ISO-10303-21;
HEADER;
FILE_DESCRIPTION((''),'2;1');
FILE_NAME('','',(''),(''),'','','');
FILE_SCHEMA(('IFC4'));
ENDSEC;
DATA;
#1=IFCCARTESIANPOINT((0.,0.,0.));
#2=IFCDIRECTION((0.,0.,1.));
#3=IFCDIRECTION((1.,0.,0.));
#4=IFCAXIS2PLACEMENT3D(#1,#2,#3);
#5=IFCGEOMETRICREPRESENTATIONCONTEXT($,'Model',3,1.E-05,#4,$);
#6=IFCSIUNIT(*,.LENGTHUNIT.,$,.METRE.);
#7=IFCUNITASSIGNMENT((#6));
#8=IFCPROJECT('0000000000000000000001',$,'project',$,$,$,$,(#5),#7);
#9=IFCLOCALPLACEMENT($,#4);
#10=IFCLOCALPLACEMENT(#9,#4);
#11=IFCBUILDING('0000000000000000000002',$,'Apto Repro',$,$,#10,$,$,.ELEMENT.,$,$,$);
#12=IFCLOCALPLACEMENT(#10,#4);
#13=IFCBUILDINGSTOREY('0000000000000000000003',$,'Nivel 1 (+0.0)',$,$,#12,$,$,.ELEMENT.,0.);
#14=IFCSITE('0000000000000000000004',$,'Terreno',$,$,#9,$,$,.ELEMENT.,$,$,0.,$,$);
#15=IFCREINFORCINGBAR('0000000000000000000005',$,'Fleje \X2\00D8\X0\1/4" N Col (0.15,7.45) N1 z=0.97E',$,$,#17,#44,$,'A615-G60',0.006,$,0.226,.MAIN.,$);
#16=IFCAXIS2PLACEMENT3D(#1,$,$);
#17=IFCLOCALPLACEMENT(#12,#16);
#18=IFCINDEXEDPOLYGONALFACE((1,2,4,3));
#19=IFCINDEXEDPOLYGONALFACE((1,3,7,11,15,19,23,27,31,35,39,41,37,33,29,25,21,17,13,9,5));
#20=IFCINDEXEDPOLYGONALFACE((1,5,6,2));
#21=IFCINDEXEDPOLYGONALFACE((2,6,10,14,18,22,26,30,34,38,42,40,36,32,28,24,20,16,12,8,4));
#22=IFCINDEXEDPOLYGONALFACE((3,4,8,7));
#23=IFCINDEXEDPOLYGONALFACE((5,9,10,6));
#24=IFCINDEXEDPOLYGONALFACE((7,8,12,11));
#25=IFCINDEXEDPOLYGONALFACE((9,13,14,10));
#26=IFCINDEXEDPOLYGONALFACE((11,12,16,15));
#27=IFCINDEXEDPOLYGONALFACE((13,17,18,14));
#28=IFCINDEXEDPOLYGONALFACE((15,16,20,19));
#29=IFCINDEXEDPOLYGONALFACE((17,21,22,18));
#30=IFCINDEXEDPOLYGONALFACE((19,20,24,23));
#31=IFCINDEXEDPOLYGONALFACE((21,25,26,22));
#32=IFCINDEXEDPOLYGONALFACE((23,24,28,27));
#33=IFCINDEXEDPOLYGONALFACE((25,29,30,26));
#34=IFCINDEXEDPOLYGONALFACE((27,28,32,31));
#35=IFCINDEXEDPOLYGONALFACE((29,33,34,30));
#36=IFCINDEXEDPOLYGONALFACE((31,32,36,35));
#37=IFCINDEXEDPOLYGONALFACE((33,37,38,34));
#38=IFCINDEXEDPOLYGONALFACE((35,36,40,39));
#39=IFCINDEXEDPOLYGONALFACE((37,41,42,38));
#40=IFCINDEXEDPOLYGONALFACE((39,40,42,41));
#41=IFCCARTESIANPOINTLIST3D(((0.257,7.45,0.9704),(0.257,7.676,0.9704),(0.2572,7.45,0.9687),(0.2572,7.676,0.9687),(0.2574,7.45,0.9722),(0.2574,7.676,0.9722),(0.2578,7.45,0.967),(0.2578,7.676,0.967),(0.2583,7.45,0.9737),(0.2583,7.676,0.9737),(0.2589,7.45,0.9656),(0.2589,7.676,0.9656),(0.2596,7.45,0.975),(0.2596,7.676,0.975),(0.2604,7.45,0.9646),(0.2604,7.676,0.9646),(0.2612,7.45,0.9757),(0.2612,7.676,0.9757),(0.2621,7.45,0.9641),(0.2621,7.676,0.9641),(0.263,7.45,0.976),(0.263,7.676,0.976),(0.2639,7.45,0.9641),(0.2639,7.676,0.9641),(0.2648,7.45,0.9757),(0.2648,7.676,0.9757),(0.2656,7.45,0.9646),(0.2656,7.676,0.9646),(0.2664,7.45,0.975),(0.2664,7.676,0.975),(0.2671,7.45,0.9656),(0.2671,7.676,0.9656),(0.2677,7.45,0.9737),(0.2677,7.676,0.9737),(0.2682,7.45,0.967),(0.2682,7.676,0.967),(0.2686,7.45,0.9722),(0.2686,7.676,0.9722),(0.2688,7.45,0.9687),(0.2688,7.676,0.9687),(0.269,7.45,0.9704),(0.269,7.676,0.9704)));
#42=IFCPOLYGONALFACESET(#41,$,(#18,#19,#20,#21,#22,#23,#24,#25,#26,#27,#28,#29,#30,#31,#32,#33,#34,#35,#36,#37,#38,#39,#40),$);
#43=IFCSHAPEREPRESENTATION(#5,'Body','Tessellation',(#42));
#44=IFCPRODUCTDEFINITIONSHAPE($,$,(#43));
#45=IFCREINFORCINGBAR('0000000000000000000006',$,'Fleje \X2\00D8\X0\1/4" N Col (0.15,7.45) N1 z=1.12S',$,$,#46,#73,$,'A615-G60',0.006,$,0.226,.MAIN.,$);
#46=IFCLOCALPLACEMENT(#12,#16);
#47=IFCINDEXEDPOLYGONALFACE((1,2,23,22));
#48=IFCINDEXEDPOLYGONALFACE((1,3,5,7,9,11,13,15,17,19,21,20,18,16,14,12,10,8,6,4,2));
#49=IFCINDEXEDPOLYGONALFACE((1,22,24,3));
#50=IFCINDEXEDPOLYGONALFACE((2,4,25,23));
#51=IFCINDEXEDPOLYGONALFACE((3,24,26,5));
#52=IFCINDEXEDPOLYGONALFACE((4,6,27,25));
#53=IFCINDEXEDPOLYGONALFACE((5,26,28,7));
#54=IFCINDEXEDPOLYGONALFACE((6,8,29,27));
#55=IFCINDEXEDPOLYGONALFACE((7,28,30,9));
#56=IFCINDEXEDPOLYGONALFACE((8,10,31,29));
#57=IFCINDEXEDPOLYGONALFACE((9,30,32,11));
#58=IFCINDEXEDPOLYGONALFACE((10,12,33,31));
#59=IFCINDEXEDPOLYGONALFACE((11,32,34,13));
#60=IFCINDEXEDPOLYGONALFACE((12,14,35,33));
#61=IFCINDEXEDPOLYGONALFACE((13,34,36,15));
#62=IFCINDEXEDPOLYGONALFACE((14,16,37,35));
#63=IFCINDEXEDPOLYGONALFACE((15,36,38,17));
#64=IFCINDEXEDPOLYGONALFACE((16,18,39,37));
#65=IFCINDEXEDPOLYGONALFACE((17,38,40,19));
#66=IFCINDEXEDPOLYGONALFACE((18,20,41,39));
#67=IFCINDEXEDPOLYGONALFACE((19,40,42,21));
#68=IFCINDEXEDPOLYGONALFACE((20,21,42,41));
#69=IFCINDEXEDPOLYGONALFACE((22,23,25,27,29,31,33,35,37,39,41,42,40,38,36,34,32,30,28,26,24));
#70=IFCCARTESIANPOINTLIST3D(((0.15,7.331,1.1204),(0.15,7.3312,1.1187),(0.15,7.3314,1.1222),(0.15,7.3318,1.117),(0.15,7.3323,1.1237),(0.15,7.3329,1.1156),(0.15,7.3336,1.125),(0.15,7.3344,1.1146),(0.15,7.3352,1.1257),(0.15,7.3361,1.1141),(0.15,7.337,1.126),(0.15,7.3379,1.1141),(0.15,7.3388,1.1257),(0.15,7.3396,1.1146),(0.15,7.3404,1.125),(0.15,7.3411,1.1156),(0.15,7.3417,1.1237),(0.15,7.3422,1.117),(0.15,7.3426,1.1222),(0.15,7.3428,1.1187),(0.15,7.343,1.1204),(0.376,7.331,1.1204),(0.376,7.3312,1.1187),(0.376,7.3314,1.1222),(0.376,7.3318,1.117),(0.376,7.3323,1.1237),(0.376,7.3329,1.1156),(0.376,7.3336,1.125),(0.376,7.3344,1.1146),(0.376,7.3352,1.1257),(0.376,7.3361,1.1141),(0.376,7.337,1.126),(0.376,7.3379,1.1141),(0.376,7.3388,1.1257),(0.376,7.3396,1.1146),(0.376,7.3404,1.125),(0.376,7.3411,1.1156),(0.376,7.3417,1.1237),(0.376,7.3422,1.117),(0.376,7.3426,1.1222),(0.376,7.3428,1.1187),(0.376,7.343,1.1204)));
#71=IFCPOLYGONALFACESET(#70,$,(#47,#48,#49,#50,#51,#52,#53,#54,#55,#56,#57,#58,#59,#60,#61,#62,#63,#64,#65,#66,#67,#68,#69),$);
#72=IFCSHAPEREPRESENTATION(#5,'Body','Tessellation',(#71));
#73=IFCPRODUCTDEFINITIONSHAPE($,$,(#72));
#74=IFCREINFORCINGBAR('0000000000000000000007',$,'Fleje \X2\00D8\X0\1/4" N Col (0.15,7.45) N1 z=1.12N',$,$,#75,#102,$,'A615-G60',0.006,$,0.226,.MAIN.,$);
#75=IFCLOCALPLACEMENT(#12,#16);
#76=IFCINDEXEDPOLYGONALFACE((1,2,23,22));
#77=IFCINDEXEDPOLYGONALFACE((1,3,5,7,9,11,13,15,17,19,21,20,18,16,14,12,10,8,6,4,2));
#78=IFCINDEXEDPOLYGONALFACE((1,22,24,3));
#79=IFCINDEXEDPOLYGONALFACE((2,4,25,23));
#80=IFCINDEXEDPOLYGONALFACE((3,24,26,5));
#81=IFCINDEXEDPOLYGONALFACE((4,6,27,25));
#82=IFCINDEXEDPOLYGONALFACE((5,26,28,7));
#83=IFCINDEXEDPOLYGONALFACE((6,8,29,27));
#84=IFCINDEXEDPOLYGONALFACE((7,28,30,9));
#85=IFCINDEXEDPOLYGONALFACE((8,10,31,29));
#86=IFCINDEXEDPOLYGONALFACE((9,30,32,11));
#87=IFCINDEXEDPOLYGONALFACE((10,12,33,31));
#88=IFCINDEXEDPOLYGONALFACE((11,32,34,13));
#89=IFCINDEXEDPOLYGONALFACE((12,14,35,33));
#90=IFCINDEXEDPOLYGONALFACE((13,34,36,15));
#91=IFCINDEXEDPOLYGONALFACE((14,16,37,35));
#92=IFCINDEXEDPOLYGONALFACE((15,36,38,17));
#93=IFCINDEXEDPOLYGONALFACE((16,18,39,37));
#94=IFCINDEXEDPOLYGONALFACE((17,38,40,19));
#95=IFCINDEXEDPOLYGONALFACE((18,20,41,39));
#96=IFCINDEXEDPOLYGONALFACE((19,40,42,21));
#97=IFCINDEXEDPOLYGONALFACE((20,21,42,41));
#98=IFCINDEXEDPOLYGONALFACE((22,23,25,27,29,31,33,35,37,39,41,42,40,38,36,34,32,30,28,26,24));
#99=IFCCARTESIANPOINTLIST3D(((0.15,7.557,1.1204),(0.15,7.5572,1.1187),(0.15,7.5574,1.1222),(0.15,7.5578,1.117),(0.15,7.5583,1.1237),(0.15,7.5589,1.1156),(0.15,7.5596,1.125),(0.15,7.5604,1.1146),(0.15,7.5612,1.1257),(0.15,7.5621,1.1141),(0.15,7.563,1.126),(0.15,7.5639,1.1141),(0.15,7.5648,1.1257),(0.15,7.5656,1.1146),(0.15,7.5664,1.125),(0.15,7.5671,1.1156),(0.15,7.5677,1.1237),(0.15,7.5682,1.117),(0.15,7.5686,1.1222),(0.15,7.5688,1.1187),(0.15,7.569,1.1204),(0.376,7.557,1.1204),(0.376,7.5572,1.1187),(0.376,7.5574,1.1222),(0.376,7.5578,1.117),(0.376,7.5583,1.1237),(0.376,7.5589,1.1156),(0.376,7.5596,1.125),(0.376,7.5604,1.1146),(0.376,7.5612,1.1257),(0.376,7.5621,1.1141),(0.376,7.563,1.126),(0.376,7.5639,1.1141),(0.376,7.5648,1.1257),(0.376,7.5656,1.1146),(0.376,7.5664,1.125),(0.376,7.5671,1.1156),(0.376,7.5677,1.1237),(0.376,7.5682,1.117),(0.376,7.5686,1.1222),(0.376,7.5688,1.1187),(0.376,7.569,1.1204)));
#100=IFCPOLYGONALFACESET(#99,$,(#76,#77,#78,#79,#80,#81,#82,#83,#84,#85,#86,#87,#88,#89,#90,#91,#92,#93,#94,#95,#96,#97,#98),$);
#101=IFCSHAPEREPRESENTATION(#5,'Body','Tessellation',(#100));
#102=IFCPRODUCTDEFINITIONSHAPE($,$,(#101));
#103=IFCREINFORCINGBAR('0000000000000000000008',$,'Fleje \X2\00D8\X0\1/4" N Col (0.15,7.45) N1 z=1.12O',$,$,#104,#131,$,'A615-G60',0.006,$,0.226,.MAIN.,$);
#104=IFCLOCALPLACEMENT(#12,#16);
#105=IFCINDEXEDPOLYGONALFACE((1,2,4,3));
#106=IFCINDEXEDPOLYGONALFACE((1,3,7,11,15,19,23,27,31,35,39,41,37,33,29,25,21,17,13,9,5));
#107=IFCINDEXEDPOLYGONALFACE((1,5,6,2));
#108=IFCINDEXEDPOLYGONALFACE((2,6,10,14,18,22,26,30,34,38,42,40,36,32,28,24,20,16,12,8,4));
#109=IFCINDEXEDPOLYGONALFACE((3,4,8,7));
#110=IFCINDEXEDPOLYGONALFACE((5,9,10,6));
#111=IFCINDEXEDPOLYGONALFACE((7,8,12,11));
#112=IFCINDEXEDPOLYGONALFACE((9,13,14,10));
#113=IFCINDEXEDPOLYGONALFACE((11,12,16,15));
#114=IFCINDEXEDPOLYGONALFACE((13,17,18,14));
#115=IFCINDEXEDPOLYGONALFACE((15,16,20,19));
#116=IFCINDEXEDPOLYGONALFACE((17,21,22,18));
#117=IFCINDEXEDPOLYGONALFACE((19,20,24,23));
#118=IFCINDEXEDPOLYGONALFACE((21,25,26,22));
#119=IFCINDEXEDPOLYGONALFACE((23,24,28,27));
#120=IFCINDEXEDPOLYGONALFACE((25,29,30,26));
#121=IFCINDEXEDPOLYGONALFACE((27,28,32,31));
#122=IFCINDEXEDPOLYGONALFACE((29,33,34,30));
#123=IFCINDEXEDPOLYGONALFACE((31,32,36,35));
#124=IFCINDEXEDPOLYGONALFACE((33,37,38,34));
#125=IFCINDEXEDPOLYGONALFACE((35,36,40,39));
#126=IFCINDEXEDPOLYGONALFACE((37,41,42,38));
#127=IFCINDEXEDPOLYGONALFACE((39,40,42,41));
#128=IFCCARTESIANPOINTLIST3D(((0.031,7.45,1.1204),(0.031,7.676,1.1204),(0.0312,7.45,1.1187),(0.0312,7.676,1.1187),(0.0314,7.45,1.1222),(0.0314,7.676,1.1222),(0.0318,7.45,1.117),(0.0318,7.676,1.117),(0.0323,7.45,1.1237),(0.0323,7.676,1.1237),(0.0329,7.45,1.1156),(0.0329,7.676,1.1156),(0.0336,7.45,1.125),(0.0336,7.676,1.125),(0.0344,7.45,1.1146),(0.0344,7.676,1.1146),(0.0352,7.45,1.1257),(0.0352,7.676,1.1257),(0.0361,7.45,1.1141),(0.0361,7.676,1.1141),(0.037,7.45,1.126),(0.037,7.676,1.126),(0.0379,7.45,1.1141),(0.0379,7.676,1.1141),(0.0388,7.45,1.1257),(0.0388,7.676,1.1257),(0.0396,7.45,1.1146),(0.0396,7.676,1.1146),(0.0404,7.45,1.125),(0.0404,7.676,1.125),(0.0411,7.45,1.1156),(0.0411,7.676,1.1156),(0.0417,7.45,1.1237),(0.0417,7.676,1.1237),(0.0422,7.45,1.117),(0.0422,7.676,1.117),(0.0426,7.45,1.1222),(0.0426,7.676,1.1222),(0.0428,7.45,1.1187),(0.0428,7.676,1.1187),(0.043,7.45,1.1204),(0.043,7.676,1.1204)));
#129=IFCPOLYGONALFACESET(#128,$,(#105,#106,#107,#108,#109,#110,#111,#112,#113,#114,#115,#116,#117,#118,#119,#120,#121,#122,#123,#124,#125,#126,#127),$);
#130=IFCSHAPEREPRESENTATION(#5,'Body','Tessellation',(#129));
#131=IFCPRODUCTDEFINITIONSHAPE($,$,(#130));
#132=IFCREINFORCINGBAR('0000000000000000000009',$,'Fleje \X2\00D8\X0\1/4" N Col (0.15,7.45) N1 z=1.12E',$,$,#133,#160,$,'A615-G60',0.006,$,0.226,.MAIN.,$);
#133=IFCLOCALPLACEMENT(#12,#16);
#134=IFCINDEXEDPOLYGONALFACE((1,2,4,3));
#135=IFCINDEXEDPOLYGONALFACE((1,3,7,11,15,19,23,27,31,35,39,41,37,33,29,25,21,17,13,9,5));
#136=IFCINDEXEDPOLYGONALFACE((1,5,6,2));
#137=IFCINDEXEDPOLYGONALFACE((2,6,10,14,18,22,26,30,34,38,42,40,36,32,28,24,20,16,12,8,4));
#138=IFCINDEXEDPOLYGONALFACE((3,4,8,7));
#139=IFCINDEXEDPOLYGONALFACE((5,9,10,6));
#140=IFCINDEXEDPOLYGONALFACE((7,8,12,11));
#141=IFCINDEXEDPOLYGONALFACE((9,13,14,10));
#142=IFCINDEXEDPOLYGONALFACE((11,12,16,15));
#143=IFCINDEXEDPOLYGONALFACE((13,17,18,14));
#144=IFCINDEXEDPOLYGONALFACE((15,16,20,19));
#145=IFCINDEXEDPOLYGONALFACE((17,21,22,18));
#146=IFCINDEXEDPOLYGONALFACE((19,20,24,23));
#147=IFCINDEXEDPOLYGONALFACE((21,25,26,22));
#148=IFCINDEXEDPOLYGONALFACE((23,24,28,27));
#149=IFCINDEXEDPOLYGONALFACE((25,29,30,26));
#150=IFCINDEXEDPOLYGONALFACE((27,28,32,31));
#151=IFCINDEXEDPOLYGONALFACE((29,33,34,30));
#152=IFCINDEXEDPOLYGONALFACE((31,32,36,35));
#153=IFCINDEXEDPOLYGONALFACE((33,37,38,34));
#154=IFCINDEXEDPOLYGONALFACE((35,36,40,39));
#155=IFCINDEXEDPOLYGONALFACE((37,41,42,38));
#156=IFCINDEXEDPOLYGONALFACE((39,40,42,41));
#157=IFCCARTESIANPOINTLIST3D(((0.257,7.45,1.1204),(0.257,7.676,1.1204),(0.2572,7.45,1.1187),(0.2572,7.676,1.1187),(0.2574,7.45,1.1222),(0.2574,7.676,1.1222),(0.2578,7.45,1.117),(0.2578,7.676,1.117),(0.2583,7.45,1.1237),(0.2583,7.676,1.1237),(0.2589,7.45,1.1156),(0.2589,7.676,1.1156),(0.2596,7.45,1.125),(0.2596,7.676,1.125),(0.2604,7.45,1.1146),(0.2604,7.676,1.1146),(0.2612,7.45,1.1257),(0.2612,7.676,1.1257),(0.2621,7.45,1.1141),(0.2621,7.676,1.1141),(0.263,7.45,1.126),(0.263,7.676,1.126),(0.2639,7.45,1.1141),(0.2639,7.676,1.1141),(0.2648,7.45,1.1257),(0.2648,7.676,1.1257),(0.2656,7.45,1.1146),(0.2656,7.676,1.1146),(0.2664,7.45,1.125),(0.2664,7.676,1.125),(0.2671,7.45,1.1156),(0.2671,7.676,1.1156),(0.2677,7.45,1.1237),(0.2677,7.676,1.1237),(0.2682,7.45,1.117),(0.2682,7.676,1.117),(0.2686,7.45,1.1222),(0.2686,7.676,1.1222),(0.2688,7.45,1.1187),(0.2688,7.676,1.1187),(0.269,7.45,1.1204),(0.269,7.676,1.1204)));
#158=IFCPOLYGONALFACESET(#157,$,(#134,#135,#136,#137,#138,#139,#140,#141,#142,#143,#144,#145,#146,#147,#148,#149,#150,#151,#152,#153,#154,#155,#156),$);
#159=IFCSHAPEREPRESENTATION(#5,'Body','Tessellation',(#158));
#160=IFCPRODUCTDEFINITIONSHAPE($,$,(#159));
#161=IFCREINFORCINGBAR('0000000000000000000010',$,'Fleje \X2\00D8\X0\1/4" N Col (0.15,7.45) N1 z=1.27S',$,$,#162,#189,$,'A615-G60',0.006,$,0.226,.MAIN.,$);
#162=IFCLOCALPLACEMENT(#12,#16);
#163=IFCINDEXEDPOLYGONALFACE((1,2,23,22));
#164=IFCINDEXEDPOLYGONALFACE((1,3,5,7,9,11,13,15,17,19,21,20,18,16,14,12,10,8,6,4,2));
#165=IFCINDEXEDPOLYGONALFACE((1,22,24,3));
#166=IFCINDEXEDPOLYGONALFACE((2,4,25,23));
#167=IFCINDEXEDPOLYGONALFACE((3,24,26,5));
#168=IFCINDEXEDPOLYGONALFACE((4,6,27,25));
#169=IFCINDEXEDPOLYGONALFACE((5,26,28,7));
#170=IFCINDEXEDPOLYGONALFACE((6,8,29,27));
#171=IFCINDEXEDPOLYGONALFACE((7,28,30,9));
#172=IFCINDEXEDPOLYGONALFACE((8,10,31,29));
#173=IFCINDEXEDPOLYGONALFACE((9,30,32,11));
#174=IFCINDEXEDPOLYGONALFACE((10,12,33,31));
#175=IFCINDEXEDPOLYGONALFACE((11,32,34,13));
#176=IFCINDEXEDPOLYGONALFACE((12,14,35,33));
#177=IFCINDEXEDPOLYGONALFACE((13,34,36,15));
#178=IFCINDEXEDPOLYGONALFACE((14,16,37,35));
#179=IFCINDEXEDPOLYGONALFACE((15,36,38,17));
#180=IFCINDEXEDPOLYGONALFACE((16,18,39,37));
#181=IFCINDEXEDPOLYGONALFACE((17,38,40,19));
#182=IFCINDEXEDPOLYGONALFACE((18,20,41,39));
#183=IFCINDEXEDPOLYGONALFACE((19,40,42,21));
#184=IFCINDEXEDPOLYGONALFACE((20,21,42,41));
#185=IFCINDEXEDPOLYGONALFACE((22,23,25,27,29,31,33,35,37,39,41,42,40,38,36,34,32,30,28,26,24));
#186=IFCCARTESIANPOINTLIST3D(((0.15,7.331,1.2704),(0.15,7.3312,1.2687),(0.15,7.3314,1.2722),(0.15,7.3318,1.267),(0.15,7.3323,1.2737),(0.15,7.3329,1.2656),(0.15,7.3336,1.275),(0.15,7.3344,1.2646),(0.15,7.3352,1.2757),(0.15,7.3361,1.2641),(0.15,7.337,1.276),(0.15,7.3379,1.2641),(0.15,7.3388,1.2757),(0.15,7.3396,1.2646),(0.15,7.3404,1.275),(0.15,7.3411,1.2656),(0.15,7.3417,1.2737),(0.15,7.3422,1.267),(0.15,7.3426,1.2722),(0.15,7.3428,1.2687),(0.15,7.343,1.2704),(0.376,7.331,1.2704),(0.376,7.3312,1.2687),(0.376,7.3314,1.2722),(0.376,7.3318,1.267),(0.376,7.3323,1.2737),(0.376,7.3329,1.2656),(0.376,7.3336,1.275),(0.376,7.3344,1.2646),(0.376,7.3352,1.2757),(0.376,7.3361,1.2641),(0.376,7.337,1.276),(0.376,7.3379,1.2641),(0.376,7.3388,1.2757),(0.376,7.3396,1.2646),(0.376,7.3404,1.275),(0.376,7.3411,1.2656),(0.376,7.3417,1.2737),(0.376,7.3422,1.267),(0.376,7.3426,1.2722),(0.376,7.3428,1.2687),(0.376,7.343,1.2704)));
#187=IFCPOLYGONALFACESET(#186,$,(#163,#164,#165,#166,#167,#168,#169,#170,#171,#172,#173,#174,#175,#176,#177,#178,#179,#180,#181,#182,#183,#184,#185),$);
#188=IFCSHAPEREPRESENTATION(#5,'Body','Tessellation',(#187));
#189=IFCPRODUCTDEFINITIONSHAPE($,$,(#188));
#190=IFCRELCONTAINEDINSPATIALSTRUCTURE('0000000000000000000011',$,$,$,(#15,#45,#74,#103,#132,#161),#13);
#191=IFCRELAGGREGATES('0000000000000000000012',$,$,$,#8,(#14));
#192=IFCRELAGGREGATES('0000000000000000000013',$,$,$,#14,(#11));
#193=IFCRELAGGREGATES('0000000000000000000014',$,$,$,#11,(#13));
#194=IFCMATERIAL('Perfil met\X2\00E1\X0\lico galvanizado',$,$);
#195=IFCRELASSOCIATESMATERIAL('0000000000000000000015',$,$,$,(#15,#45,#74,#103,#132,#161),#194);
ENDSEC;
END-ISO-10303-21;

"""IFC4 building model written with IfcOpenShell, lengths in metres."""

from ifc_helpers import new_model, si_unit, frame, origin_with_axes, origin_2d_with_axis, place, context, project, spatial, circle, extrude, material, element, save


model = new_model("IFC4")

# Units and contexts
model_context = context("Model", 3, precision=1e-05, world=origin_with_axes())
ifc_project = project(units=[si_unit("LENGTHUNIT", "METRE")], contexts=[model_context])

# Site, building, storey
site_placement = place(None, origin_with_axes())
site = spatial("IfcSite", under=ifc_project, at=site_placement, Name="Terreno", CompositionType="ELEMENT", RefElevation=0.0)
building_placement = place(site_placement, origin_with_axes())
building = spatial("IfcBuilding", under=site, at=building_placement, Name="Apto Repro", CompositionType="ELEMENT")
storey_placement = place(building_placement, origin_with_axes())
storey = spatial("IfcBuildingStorey", under=building, at=storey_placement, Name="Nivel 1 (+0.0)", CompositionType="ELEMENT", Elevation=0.0)

# Reinforcing bars
ifc_material = material(Name="Perfil metálico galvanizado")
reinforcing_bar_1_placement = place(storey_placement, origin_with_axes())
element("IfcReinforcingBar", 1, at=reinforcing_bar_1_placement, inside=storey, material=ifc_material, Name="Fleje Ø1/4\" N Col (0.15,7.45) N1 z=0.97E", SteelGrade="A615-G60", BarLength=0.226, NominalDiameter=0.006, PredefinedType="MAIN", context=model_context, shape_type="SweptSolid", body=[
    extrude(circle(Radius=0.006, at=origin_2d_with_axis()), frame((0.263, 7.45, 0.97), z_axis=(0.0, 1.0, 0.0), x_axis=(0.0, 0.0, 1.0)), (0.0, 0.0, 1.0), 0.226),
])
reinforcing_bar_2_placement = place(storey_placement, origin_with_axes())
element("IfcReinforcingBar", 2, at=reinforcing_bar_2_placement, inside=storey, material=ifc_material, Name="Fleje Ø1/4\" N Col (0.15,7.45) N1 z=1.12S", SteelGrade="A615-G60", BarLength=0.226, NominalDiameter=0.006, PredefinedType="MAIN", context=model_context, shape_type="SweptSolid", body=[
    extrude(circle(Radius=0.006, at=origin_2d_with_axis()), frame((0.15, 7.337, 1.12), z_axis=(1.0, 0.0, 0.0), x_axis=(0.0, 0.0, 1.0)), (0.0, 0.0, 1.0), 0.226),
])
reinforcing_bar_3_placement = place(storey_placement, origin_with_axes())
element("IfcReinforcingBar", 3, at=reinforcing_bar_3_placement, inside=storey, material=ifc_material, Name="Fleje Ø1/4\" N Col (0.15,7.45) N1 z=1.12N", SteelGrade="A615-G60", BarLength=0.226, NominalDiameter=0.006, PredefinedType="MAIN", context=model_context, shape_type="SweptSolid", body=[
    extrude(circle(Radius=0.006, at=origin_2d_with_axis()), frame((0.15, 7.563, 1.12), z_axis=(1.0, 0.0, 0.0), x_axis=(0.0, 0.0, 1.0)), (0.0, 0.0, 1.0), 0.226),
])
reinforcing_bar_4_placement = place(storey_placement, origin_with_axes())
element("IfcReinforcingBar", 4, at=reinforcing_bar_4_placement, inside=storey, material=ifc_material, Name="Fleje Ø1/4\" N Col (0.15,7.45) N1 z=1.12O", SteelGrade="A615-G60", BarLength=0.226, NominalDiameter=0.006, PredefinedType="MAIN", context=model_context, shape_type="SweptSolid", body=[
    extrude(circle(Radius=0.006, at=origin_2d_with_axis()), frame((0.037, 7.45, 1.12), z_axis=(0.0, 1.0, 0.0), x_axis=(0.0, 0.0, 1.0)), (0.0, 0.0, 1.0), 0.226),
])
reinforcing_bar_5_placement = place(storey_placement, origin_with_axes())
element("IfcReinforcingBar", 5, at=reinforcing_bar_5_placement, inside=storey, material=ifc_material, Name="Fleje Ø1/4\" N Col (0.15,7.45) N1 z=1.12E", SteelGrade="A615-G60", BarLength=0.226, NominalDiameter=0.006, PredefinedType="MAIN", context=model_context, shape_type="SweptSolid", body=[
    extrude(circle(Radius=0.006, at=origin_2d_with_axis()), frame((0.263, 7.45, 1.12), z_axis=(0.0, 1.0, 0.0), x_axis=(0.0, 0.0, 1.0)), (0.0, 0.0, 1.0), 0.226),
])
reinforcing_bar_6_placement = place(storey_placement, origin_with_axes())
element("IfcReinforcingBar", 6, at=reinforcing_bar_6_placement, inside=storey, material=ifc_material, Name="Fleje Ø1/4\" N Col (0.15,7.45) N1 z=1.27S", SteelGrade="A615-G60", BarLength=0.226, NominalDiameter=0.006, PredefinedType="MAIN", context=model_context, shape_type="SweptSolid", body=[
    extrude(circle(Radius=0.006, at=origin_2d_with_axis()), frame((0.15, 7.337, 1.27), z_axis=(1.0, 0.0, 0.0), x_axis=(0.0, 0.0, 1.0)), (0.0, 0.0, 1.0), 0.226),
])

save(model, "model.ifc")
